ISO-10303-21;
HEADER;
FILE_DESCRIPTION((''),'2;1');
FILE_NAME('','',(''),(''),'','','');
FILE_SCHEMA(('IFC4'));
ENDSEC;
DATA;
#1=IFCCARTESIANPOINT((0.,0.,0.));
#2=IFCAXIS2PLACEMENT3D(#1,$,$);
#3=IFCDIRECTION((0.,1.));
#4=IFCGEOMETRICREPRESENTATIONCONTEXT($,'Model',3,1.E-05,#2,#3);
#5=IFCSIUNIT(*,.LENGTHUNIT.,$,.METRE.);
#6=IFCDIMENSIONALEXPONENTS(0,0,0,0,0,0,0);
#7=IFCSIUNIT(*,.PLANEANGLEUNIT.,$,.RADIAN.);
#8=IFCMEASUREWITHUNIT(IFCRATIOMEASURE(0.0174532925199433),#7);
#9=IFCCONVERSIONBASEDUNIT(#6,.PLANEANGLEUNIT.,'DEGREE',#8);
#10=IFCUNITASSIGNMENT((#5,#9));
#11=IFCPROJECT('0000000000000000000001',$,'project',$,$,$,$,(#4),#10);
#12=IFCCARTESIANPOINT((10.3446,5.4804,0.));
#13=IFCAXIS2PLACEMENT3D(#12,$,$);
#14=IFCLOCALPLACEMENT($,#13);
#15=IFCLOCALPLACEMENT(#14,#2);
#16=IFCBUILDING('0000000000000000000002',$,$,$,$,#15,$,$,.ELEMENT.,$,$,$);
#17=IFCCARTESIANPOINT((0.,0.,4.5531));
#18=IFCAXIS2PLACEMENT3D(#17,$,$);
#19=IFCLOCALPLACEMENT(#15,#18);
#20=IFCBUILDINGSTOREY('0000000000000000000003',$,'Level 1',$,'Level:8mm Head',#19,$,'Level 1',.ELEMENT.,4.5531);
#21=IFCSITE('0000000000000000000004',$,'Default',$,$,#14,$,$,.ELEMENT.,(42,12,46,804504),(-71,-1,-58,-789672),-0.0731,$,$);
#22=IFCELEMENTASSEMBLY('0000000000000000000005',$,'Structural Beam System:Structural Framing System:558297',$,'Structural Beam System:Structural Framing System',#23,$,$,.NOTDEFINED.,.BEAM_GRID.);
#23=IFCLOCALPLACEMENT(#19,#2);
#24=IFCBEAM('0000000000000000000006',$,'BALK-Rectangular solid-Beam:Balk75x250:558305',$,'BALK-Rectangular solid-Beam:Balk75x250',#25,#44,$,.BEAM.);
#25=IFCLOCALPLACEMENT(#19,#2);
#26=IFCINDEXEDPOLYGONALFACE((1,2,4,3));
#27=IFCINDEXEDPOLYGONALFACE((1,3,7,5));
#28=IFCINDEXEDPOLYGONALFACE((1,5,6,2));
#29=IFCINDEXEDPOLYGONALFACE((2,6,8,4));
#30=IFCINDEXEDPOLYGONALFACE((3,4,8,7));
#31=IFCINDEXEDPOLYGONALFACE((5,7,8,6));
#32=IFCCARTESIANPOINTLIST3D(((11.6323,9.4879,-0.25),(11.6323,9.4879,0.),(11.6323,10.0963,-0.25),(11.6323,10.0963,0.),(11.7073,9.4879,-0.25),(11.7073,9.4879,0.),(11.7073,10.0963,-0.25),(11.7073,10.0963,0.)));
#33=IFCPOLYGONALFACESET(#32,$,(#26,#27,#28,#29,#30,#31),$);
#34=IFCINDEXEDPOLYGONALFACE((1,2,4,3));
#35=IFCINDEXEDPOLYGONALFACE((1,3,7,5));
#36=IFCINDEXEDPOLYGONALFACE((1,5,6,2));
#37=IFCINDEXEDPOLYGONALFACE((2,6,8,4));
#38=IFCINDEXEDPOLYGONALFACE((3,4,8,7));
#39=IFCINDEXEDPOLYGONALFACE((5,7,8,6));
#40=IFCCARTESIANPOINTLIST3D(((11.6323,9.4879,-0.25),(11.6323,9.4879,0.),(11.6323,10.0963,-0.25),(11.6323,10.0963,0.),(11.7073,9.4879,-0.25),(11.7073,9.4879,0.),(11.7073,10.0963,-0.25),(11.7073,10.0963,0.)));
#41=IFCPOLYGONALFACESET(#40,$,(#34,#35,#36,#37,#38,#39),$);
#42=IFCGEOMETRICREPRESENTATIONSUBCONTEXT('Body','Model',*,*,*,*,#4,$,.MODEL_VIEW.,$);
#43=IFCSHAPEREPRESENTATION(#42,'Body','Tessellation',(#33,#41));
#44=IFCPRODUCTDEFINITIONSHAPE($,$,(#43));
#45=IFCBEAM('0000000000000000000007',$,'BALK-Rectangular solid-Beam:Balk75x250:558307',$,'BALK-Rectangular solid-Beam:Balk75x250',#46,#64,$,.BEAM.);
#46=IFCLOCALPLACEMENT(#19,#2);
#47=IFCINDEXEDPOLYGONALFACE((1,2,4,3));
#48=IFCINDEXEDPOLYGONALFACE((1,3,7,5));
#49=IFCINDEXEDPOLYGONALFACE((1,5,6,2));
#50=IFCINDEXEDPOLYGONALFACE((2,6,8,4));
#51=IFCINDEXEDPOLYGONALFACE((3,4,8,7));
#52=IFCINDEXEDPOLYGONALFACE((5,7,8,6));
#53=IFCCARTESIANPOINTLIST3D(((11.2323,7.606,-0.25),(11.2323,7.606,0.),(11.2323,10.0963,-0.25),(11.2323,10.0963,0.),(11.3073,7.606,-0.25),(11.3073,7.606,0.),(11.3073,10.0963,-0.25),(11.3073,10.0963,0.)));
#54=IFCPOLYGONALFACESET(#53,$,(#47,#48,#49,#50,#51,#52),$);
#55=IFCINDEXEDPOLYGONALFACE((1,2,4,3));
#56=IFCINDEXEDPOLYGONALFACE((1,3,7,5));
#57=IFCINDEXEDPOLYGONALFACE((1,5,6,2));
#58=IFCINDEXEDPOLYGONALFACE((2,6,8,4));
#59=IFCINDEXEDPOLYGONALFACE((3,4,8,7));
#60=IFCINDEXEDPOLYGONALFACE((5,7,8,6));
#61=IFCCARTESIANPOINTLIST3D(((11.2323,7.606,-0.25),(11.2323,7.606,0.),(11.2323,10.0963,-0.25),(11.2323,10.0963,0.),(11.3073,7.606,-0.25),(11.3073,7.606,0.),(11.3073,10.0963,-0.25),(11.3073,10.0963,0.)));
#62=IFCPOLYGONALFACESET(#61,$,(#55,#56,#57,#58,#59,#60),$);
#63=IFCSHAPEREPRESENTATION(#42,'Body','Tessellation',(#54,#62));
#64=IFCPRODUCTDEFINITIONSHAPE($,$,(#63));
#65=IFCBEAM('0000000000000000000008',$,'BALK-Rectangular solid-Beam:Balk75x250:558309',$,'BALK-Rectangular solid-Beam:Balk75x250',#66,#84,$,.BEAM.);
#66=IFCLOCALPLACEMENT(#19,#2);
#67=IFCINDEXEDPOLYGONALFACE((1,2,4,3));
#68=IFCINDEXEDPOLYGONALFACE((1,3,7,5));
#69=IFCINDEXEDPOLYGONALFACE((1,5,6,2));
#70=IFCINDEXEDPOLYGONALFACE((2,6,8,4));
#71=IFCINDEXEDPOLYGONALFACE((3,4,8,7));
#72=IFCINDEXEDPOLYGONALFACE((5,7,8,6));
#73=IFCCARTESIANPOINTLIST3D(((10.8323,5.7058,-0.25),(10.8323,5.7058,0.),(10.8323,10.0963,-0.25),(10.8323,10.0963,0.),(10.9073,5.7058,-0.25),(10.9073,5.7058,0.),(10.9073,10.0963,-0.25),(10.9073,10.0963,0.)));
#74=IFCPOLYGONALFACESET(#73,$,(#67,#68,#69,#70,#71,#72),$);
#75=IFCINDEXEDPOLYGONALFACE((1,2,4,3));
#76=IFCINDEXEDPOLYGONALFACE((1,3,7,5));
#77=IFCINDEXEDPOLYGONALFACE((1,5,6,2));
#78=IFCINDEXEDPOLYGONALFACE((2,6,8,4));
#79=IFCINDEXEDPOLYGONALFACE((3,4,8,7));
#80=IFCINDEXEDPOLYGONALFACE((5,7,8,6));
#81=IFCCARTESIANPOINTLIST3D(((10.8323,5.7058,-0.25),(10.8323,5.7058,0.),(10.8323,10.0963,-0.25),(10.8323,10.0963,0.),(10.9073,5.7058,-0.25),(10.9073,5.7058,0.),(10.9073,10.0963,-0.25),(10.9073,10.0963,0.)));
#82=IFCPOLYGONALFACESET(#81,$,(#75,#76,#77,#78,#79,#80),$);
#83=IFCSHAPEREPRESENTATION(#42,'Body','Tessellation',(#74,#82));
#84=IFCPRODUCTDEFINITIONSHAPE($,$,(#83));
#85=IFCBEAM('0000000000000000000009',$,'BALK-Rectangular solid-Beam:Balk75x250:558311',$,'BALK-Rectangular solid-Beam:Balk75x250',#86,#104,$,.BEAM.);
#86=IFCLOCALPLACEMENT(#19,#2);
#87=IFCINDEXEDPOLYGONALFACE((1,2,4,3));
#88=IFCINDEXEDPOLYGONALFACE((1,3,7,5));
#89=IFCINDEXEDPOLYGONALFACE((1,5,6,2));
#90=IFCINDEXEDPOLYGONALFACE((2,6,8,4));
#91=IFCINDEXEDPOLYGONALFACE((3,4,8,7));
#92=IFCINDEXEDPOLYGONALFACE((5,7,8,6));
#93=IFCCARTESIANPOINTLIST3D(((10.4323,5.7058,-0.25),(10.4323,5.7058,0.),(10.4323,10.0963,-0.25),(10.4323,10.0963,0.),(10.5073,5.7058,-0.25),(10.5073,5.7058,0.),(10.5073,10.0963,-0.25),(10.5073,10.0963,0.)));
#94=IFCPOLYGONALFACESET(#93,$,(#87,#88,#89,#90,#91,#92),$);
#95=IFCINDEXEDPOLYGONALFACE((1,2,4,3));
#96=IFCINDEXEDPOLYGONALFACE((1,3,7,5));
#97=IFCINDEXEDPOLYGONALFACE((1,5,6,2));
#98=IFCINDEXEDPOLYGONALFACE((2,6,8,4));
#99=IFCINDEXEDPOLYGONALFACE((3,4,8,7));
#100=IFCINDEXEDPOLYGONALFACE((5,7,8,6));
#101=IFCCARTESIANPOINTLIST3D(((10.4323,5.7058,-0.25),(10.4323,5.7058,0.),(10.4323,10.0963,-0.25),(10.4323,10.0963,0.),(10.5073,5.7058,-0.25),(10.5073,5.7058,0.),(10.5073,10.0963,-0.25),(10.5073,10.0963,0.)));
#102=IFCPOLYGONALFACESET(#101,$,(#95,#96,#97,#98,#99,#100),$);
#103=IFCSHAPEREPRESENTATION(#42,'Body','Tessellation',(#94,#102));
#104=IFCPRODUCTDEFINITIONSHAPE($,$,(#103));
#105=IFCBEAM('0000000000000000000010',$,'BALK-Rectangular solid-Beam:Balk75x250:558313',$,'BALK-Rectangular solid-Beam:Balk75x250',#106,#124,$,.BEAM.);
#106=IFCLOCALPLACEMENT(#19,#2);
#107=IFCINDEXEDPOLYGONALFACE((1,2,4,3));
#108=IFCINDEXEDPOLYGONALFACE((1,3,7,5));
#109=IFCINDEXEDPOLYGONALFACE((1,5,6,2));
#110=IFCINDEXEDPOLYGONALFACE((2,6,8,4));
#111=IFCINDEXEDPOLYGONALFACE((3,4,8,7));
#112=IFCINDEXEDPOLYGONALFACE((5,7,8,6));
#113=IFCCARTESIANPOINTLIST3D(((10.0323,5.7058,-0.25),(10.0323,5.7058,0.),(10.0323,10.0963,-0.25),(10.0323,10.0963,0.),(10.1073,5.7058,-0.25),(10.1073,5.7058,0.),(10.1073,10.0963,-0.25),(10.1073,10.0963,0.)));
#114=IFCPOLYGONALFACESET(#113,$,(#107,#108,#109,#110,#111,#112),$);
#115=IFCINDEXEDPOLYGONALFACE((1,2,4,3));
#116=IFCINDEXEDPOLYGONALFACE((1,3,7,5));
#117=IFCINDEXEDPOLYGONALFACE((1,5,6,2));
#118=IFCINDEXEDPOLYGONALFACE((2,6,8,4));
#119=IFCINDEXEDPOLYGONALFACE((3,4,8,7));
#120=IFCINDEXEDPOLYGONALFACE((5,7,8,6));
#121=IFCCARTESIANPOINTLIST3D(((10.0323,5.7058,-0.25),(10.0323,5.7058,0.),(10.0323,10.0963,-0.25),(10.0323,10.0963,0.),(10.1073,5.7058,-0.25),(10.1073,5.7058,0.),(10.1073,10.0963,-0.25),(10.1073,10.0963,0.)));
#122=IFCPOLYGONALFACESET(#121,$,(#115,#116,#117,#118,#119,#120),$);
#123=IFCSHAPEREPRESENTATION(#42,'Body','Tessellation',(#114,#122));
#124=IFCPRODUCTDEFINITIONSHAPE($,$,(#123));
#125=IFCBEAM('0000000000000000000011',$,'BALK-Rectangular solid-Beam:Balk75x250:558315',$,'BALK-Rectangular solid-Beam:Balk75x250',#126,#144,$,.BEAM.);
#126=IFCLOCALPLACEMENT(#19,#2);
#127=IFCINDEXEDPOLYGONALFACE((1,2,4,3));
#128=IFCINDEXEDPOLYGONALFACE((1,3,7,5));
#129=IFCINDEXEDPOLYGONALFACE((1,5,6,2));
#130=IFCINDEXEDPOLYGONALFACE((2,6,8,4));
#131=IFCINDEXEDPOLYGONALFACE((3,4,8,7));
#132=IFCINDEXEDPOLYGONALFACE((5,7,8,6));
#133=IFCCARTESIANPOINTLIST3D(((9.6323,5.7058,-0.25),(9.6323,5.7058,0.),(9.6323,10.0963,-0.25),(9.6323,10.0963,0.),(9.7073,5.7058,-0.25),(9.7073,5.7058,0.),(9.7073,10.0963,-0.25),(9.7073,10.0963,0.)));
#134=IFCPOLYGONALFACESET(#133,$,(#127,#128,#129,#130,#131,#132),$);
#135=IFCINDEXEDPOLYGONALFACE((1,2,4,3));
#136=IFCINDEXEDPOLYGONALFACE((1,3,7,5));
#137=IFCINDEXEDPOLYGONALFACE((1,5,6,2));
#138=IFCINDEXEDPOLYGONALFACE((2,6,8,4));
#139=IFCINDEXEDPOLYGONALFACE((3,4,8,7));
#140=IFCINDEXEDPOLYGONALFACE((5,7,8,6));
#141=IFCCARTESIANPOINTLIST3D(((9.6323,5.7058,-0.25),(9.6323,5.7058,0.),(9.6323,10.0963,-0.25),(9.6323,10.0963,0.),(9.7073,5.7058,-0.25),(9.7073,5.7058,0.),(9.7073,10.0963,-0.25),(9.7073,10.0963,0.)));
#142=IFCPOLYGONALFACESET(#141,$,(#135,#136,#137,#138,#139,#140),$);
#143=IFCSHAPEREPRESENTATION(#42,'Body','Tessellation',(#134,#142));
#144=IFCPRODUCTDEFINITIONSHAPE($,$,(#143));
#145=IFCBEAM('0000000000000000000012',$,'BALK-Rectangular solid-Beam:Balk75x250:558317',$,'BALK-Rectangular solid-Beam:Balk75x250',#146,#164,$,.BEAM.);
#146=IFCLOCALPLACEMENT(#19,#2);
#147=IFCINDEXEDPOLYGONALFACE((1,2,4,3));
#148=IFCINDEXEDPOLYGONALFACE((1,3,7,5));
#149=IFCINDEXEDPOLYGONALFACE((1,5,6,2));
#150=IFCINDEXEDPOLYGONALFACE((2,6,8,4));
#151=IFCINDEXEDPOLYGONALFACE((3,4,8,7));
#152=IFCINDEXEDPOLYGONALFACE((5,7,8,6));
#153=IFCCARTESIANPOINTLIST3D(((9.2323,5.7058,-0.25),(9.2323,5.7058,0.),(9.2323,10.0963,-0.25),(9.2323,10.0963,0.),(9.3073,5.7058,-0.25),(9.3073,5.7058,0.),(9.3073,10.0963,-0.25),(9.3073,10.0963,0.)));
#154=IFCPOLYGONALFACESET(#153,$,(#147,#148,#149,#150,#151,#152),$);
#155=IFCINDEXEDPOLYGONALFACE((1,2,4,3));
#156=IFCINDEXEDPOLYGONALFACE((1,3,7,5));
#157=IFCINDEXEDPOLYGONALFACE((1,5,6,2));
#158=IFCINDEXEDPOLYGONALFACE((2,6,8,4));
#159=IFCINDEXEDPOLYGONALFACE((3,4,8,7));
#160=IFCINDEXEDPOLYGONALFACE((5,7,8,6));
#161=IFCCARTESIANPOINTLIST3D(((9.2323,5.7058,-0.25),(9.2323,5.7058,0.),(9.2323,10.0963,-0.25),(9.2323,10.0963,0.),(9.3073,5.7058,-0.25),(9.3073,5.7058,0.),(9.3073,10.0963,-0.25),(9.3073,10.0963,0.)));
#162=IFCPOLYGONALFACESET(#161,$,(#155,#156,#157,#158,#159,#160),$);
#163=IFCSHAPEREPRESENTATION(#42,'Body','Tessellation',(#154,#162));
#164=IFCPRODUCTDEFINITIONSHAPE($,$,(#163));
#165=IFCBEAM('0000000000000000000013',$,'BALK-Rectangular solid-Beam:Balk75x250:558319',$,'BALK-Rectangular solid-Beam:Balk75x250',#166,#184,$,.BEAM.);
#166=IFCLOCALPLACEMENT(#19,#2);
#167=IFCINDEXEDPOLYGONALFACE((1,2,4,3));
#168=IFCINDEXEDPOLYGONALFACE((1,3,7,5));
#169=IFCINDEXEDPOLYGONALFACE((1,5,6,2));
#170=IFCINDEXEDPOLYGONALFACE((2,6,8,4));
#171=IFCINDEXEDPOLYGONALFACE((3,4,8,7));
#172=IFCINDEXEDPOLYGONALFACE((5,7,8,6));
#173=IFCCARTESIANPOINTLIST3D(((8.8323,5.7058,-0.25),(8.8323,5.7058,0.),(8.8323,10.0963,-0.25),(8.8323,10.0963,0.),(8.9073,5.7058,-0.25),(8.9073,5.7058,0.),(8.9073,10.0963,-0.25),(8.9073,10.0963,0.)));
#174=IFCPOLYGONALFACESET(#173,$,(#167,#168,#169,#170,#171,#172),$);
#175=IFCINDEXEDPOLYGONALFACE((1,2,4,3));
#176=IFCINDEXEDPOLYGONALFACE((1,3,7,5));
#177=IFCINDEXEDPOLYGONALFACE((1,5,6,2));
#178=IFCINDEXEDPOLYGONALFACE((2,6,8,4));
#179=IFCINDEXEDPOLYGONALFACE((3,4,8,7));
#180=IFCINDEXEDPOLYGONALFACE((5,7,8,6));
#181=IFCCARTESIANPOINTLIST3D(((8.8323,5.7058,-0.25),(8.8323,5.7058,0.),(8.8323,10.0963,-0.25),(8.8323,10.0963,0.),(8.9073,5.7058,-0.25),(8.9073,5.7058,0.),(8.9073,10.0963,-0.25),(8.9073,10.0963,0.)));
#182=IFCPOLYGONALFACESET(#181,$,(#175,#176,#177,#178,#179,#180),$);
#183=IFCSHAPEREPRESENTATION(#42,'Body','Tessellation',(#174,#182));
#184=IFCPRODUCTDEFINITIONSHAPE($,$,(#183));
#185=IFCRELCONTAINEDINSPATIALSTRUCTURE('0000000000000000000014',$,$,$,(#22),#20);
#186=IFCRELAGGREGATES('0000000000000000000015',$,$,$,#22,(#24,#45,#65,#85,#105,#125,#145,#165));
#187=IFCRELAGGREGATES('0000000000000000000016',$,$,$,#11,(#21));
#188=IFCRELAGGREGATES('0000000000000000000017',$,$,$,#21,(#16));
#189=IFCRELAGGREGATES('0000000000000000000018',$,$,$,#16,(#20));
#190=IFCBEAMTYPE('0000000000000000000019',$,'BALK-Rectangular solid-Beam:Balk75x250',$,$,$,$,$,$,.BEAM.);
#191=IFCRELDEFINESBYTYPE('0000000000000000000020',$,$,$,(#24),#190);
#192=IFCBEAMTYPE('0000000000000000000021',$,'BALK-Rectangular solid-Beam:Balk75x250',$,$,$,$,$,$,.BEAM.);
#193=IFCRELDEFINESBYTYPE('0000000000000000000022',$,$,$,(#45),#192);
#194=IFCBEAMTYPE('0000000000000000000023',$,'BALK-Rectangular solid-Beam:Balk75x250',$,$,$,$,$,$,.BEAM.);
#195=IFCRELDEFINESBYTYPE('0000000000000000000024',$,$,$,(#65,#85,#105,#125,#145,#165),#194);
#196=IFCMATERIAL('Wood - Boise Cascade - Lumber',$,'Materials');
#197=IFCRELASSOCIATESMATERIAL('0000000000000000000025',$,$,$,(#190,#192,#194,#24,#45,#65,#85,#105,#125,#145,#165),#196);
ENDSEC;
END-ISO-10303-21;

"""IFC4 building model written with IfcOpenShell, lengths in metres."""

from ifc_helpers import new_model, entity, si_unit, converted_unit, direction, frame, frame_2d, origin, origin_2d_with_axis, place, context, subcontext, project, spatial, rectangle, extrude, source, transform, mapped, material, material_profile, profile_set, profile_usage, type_object, type_shapes, element, aggregate, save


model = new_model("IFC4")

# Units and contexts
model_context = context("Model", 3, precision=1e-05, world=origin(), true_north=direction((0.0, 1.0)))
body_context = subcontext(model_context, "Body", "Model", "MODEL_VIEW")
ifc_project = project(units=[si_unit("LENGTHUNIT", "METRE"), converted_unit("PLANEANGLEUNIT", "DEGREE", entity("IfcRatioMeasure", 0.0174532925199433), si_unit("PLANEANGLEUNIT", "RADIAN"), dimensions=[0, 0, 0, 0, 0, 0, 0])], contexts=[model_context])

# Site, building, storey
site_placement = place(None, frame((10.3446, 5.4804, 0.0)))
site = spatial("IfcSite", under=ifc_project, at=site_placement, Name="Default", CompositionType="ELEMENT", RefLatitude=(42, 12, 46, 804504), RefLongitude=(-71, -1, -58, -789672), RefElevation=-0.0731)
building_placement = place(site_placement, origin())
building = spatial("IfcBuilding", under=site, at=building_placement, CompositionType="ELEMENT")
storey_placement = place(building_placement, frame((0.0, 0.0, 4.5531)))
storey = spatial("IfcBuildingStorey", under=building, at=storey_placement, Name="Level 1", ObjectType="Level:8mm Head", LongName="Level 1", CompositionType="ELEMENT", Elevation=4.5531)

# Element assembly, beams
assembly_1_placement = place(storey_placement, origin())
assembly_1 = element("IfcElementAssembly", 1, at=assembly_1_placement, inside=storey, Name="Structural Beam System:Structural Framing System:558297", ObjectType="Structural Beam System:Structural Framing System", AssemblyPlace="NOTDEFINED", PredefinedType="BEAM_GRID")
ifc_material_1 = material(Name="Wood - Boise Cascade - Lumber", Category="Materials")
ifc_material_profile = material_profile(ifc_material_1, rectangle(XDim=0.25, YDim=0.075, at=frame_2d((0.0, 0.0), x_axis=(1.0, 0.0))), Name="Balk75x250")
ifc_profile_set = profile_set([ifc_material_profile], Name="Balk75x250")
ifc_profile_usage_1 = profile_usage(ifc_profile_set, cardinal=8)
beam_type_1 = type_object("IfcBeamType", Name="BALK-Rectangular solid-Beam:Balk75x250", PredefinedType="BEAM", material=ifc_profile_set)
shared_shape_1 = source(origin(), body_context, "Body", "SweptSolid", [
    extrude(rectangle(XDim=0.25, YDim=0.075, at=origin_2d_with_axis()), frame((-0.9163, 0.0, 0.0), z_axis=(1.0, 0.0, 0.0), x_axis=(0.0, 0.0, -1.0)), (0.0, 0.0, 1.0), 0.6084),
    extrude(rectangle(XDim=0.25, YDim=0.075, at=origin_2d_with_axis()), frame((-0.9163, 0.0, 0.0), z_axis=(1.0, 0.0, 0.0), x_axis=(0.0, 0.0, -1.0)), (0.0, 0.0, 1.0), 0.6084),
])
type_shapes(beam_type_1, [shared_shape_1])
beam_1_placement = place(assembly_1_placement, frame((11.6698, 9.18, -0.125), z_axis=(0.0, 0.0, 1.0), x_axis=(0.0, -1.0, 0.0)))
beam_1 = element("IfcBeam", 2, at=beam_1_placement, type_object=beam_type_1, material=ifc_profile_usage_1, Name="BALK-Rectangular solid-Beam:Balk75x250:558305", ObjectType="BALK-Rectangular solid-Beam:Balk75x250", PredefinedType="BEAM", context=body_context, shape_type="MappedRepresentation", body=[
    mapped(shared_shape_1, transform((0.0, 0.0, 0.0), scale=1.0)),
])
ifc_profile_usage_2 = profile_usage(ifc_profile_set, cardinal=8)
beam_type_2 = type_object("IfcBeamType", Name="BALK-Rectangular solid-Beam:Balk75x250", PredefinedType="BEAM", material=ifc_profile_set)
shared_shape_2 = source(origin(), body_context, "Body", "SweptSolid", [
    extrude(rectangle(XDim=0.25, YDim=0.075, at=origin_2d_with_axis()), frame((-1.8572, 0.0, 0.0), z_axis=(1.0, 0.0, 0.0), x_axis=(0.0, 0.0, -1.0)), (0.0, 0.0, 1.0), 2.4903),
    extrude(rectangle(XDim=0.25, YDim=0.075, at=origin_2d_with_axis()), frame((-1.8572, 0.0, 0.0), z_axis=(1.0, 0.0, 0.0), x_axis=(0.0, 0.0, -1.0)), (0.0, 0.0, 1.0), 2.4903),
])
type_shapes(beam_type_2, [shared_shape_2])
beam_2_placement = place(assembly_1_placement, frame((11.2698, 8.2391, -0.125), z_axis=(0.0, 0.0, 1.0), x_axis=(0.0, -1.0, 0.0)))
beam_2 = element("IfcBeam", 3, at=beam_2_placement, type_object=beam_type_2, material=ifc_profile_usage_2, Name="BALK-Rectangular solid-Beam:Balk75x250:558307", ObjectType="BALK-Rectangular solid-Beam:Balk75x250", PredefinedType="BEAM", context=body_context, shape_type="MappedRepresentation", body=[
    mapped(shared_shape_2, transform((0.0, 0.0, 0.0), scale=1.0)),
])
ifc_profile_usage_3 = profile_usage(ifc_profile_set, cardinal=8)
beam_type_3 = type_object("IfcBeamType", Name="BALK-Rectangular solid-Beam:Balk75x250", PredefinedType="BEAM", material=ifc_profile_set)
shared_shape_3 = source(origin(), body_context, "Body", "SweptSolid", [
    extrude(rectangle(XDim=0.25, YDim=0.075, at=origin_2d_with_axis()), frame((-2.089, 0.0, 0.0), z_axis=(1.0, 0.0, 0.0), x_axis=(0.0, 0.0, -1.0)), (0.0, 0.0, 1.0), 4.3905),
    extrude(rectangle(XDim=0.25, YDim=0.075, at=origin_2d_with_axis()), frame((-2.089, 0.0, 0.0), z_axis=(1.0, 0.0, 0.0), x_axis=(0.0, 0.0, -1.0)), (0.0, 0.0, 1.0), 4.3905),
])
type_shapes(beam_type_3, [shared_shape_3])
beam_3_placement = place(assembly_1_placement, frame((10.8698, 8.0073, -0.125), z_axis=(0.0, 0.0, 1.0), x_axis=(0.0, -1.0, 0.0)))
beam_3 = element("IfcBeam", 4, at=beam_3_placement, type_object=beam_type_3, material=ifc_profile_usage_3, Name="BALK-Rectangular solid-Beam:Balk75x250:558309", ObjectType="BALK-Rectangular solid-Beam:Balk75x250", PredefinedType="BEAM", context=body_context, shape_type="MappedRepresentation", body=[
    mapped(shared_shape_3, transform((0.0, 0.0, 0.0), scale=1.0)),
])
ifc_profile_usage_4 = profile_usage(ifc_profile_set, cardinal=8)
beam_4_placement = place(assembly_1_placement, frame((10.4698, 8.0073, -0.125), z_axis=(0.0, 0.0, 1.0), x_axis=(0.0, -1.0, 0.0)))
beam_4 = element("IfcBeam", 5, at=beam_4_placement, type_object=beam_type_3, material=ifc_profile_usage_4, Name="BALK-Rectangular solid-Beam:Balk75x250:558311", ObjectType="BALK-Rectangular solid-Beam:Balk75x250", PredefinedType="BEAM", context=body_context, shape_type="MappedRepresentation", body=[
    mapped(shared_shape_3, transform((0.0, 0.0, 0.0), scale=1.0)),
])
ifc_profile_usage_5 = profile_usage(ifc_profile_set, cardinal=8)
beam_5_placement = place(assembly_1_placement, frame((10.0698, 8.0073, -0.125), z_axis=(0.0, 0.0, 1.0), x_axis=(0.0, -1.0, 0.0)))
beam_5 = element("IfcBeam", 6, at=beam_5_placement, type_object=beam_type_3, material=ifc_profile_usage_5, Name="BALK-Rectangular solid-Beam:Balk75x250:558313", ObjectType="BALK-Rectangular solid-Beam:Balk75x250", PredefinedType="BEAM", context=body_context, shape_type="MappedRepresentation", body=[
    mapped(shared_shape_3, transform((0.0, 0.0, 0.0), scale=1.0)),
])
ifc_profile_usage_6 = profile_usage(ifc_profile_set, cardinal=8)
beam_6_placement = place(assembly_1_placement, frame((9.6698, 8.0073, -0.125), z_axis=(0.0, 0.0, 1.0), x_axis=(0.0, -1.0, 0.0)))
beam_6 = element("IfcBeam", 7, at=beam_6_placement, type_object=beam_type_3, material=ifc_profile_usage_6, Name="BALK-Rectangular solid-Beam:Balk75x250:558315", ObjectType="BALK-Rectangular solid-Beam:Balk75x250", PredefinedType="BEAM", context=body_context, shape_type="MappedRepresentation", body=[
    mapped(shared_shape_3, transform((0.0, 0.0, 0.0), scale=1.0)),
])
ifc_profile_usage_7 = profile_usage(ifc_profile_set, cardinal=8)
beam_7_placement = place(assembly_1_placement, frame((9.2698, 8.0073, -0.125), z_axis=(0.0, 0.0, 1.0), x_axis=(0.0, -1.0, 0.0)))
beam_7 = element("IfcBeam", 8, at=beam_7_placement, type_object=beam_type_3, material=ifc_profile_usage_7, Name="BALK-Rectangular solid-Beam:Balk75x250:558317", ObjectType="BALK-Rectangular solid-Beam:Balk75x250", PredefinedType="BEAM", context=body_context, shape_type="MappedRepresentation", body=[
    mapped(shared_shape_3, transform((0.0, 0.0, 0.0), scale=1.0)),
])
ifc_profile_usage_8 = profile_usage(ifc_profile_set, cardinal=8)
beam_8_placement = place(assembly_1_placement, frame((8.8698, 8.0073, -0.125), z_axis=(0.0, 0.0, 1.0), x_axis=(0.0, -1.0, 0.0)))
beam_8 = element("IfcBeam", 9, at=beam_8_placement, type_object=beam_type_3, material=ifc_profile_usage_8, Name="BALK-Rectangular solid-Beam:Balk75x250:558319", ObjectType="BALK-Rectangular solid-Beam:Balk75x250", PredefinedType="BEAM", context=body_context, shape_type="MappedRepresentation", body=[
    mapped(shared_shape_3, transform((0.0, 0.0, 0.0), scale=1.0)),
])
aggregate(assembly_1, [beam_1, beam_2, beam_3, beam_4, beam_5, beam_6, beam_7, beam_8])

save(model, "model.ifc")
